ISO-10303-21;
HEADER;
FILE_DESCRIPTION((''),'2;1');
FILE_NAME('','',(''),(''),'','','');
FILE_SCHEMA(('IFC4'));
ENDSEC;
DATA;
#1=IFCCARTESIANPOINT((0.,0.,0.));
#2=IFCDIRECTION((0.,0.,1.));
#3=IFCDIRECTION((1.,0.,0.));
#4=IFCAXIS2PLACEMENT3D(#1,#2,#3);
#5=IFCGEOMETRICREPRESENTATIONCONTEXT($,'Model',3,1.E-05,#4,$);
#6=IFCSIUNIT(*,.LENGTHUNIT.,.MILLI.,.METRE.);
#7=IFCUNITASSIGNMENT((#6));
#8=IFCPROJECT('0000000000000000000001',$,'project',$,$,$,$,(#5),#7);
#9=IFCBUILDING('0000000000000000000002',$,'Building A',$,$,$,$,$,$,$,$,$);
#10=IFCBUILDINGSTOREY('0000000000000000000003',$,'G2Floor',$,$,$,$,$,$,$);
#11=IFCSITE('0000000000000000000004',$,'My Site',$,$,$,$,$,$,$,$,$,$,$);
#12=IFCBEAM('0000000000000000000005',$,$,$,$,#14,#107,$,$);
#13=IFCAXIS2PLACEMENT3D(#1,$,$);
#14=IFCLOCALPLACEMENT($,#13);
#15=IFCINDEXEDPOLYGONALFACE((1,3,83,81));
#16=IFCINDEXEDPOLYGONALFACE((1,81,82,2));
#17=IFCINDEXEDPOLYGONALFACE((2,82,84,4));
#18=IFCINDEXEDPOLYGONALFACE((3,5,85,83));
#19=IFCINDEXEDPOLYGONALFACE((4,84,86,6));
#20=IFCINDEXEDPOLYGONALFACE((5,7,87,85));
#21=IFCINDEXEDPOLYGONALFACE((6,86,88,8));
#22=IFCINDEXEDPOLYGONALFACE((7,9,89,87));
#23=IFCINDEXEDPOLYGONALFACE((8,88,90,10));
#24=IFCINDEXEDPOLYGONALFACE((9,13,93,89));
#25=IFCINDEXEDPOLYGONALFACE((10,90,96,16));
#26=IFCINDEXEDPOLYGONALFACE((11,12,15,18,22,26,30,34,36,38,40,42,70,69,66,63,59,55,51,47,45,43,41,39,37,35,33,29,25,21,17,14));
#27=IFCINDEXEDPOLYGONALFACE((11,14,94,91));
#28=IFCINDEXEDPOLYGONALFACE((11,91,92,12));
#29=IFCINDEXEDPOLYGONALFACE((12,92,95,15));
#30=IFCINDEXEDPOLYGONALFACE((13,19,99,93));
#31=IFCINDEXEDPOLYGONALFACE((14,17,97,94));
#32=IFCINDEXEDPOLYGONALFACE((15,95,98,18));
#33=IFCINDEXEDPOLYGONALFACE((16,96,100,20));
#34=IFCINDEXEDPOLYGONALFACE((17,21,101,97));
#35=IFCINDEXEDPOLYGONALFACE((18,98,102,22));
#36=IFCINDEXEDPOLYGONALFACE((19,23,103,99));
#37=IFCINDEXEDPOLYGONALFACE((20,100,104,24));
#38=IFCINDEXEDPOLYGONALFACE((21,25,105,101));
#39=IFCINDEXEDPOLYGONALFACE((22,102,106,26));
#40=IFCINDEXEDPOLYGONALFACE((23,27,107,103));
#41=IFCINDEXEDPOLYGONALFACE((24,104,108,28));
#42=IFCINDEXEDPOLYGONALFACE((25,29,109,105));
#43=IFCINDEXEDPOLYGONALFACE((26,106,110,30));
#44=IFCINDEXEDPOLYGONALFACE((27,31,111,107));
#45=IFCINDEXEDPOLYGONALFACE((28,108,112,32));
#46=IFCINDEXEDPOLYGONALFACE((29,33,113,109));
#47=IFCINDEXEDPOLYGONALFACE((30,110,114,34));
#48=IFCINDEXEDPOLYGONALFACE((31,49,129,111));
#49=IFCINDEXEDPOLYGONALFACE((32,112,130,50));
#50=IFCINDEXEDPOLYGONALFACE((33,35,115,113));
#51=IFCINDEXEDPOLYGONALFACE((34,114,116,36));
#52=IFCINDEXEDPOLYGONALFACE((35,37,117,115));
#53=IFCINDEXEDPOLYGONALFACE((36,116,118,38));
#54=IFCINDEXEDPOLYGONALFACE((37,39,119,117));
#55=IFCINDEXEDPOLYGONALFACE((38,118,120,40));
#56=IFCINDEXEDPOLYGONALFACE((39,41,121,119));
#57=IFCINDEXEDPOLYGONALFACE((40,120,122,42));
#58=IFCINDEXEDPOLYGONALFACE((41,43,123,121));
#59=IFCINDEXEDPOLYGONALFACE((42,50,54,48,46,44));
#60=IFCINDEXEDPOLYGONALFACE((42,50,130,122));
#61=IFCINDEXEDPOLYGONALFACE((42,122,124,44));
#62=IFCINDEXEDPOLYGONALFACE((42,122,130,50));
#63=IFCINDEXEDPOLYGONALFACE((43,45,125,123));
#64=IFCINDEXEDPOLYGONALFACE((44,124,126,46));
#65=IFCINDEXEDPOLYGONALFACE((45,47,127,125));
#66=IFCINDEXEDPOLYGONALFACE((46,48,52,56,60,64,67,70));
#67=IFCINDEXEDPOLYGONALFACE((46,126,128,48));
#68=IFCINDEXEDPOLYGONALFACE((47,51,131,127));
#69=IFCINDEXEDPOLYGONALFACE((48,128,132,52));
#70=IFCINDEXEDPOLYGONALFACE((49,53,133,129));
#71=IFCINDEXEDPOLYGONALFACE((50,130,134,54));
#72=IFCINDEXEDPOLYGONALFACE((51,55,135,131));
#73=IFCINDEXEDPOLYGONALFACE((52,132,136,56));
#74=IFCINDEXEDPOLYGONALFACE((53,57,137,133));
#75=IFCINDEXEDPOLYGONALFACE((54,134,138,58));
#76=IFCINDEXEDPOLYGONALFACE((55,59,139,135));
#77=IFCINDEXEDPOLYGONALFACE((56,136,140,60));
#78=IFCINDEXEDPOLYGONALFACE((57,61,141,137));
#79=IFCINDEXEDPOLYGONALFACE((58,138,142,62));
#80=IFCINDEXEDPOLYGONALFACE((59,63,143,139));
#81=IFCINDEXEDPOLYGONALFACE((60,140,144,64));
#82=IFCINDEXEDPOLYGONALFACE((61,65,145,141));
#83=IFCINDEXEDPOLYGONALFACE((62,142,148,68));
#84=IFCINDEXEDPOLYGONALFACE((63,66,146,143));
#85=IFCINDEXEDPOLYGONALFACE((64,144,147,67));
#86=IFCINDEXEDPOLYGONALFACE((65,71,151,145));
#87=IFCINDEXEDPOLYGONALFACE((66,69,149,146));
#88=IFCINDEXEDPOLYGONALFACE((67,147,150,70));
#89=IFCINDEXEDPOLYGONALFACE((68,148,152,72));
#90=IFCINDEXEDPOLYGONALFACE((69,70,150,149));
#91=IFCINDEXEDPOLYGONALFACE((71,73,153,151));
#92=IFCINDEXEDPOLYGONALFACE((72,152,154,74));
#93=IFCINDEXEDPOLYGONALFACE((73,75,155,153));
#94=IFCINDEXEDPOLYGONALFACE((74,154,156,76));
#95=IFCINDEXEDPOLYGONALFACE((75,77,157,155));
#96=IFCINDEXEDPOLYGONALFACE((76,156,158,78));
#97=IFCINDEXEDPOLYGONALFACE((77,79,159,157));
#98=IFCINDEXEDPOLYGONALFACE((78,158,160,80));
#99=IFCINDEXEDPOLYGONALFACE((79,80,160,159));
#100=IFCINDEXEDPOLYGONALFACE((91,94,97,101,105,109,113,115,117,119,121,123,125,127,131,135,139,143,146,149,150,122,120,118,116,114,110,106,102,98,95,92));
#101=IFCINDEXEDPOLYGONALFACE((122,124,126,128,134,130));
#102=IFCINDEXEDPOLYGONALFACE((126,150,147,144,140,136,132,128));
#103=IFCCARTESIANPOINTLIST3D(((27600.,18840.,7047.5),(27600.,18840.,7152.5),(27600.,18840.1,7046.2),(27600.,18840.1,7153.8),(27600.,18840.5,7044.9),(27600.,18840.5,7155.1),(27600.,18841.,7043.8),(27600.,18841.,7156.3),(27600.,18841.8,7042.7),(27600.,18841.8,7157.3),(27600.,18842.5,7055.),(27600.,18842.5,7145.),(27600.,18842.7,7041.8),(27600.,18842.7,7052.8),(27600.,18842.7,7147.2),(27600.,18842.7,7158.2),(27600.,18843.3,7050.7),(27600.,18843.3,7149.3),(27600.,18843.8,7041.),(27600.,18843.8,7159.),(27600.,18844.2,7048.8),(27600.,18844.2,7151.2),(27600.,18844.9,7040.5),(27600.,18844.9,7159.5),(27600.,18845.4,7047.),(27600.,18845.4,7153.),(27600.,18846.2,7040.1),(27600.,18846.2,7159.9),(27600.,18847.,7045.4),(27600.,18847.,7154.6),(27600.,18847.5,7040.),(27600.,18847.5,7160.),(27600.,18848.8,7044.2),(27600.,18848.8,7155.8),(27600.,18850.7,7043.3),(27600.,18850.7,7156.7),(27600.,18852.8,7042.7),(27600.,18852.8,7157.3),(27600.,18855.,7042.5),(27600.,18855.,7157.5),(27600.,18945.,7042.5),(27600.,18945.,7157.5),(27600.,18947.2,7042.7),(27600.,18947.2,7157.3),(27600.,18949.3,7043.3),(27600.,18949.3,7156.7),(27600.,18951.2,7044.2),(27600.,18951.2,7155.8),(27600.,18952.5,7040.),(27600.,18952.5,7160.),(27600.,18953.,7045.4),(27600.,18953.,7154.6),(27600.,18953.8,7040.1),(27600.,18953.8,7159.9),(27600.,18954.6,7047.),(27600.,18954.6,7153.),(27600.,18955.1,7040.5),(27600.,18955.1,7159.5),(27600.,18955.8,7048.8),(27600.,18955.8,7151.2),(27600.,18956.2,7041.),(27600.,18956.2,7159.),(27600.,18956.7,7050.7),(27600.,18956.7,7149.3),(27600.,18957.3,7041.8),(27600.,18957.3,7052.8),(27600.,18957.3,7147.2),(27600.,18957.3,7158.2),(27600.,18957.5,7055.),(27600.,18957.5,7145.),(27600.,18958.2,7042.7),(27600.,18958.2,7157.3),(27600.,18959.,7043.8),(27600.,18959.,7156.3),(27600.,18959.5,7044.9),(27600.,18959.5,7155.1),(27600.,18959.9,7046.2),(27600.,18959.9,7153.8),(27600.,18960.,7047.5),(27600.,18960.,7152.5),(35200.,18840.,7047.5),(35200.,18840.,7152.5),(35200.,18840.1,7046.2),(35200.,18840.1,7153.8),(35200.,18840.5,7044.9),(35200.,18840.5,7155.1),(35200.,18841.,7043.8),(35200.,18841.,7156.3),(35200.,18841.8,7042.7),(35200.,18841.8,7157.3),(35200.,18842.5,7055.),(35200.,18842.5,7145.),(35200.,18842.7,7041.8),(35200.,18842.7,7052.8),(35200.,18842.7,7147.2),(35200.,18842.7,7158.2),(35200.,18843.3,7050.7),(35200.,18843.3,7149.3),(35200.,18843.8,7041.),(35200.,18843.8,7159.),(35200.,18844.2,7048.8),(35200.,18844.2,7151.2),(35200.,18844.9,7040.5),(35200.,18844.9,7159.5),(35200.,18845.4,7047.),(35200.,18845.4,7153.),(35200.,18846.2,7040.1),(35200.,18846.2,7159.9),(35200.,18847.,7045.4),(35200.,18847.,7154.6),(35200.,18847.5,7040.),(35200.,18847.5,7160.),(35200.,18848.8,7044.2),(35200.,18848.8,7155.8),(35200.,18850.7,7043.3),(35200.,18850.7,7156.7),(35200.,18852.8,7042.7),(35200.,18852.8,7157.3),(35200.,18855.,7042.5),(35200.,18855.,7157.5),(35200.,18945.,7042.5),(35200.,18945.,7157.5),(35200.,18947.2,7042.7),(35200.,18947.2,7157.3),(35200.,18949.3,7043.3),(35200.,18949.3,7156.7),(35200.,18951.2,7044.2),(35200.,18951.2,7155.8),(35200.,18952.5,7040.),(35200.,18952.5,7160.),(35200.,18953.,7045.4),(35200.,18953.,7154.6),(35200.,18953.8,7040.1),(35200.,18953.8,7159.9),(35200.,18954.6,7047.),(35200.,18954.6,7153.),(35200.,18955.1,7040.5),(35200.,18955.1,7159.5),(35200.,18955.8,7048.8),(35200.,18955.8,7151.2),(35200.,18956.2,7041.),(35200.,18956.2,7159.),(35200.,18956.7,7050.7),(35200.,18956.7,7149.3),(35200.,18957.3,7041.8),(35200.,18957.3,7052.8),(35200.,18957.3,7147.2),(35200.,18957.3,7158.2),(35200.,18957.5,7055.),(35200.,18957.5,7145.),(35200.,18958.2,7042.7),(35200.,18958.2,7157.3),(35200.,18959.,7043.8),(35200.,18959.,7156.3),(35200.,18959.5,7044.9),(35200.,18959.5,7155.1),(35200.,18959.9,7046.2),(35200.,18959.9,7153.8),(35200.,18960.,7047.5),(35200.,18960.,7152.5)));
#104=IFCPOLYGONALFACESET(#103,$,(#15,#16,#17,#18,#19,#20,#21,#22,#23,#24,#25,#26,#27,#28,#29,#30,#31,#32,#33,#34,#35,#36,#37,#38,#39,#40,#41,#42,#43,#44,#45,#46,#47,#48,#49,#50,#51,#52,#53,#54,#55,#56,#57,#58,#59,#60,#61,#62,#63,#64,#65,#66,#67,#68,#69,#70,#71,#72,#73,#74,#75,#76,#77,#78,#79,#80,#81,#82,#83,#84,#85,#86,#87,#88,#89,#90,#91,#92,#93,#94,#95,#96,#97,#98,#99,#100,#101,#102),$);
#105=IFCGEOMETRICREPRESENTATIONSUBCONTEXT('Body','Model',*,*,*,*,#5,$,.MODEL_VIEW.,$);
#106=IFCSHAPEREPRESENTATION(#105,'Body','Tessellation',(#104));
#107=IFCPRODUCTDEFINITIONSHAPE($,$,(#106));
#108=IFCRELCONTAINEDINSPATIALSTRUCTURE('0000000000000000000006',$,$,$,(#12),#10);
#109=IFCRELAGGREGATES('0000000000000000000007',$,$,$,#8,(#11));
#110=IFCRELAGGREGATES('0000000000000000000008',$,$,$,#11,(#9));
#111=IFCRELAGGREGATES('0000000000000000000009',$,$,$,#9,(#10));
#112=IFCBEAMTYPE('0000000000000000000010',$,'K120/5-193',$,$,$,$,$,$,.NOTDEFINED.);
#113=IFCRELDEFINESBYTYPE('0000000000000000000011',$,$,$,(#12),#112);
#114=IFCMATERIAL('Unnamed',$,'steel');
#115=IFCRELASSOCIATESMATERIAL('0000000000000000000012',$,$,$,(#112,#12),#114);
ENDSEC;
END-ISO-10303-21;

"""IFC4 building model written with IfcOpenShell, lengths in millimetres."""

from ifc_helpers import new_model, si_unit, frame, origin_with_axes, place, context, subcontext, project, spatial, polyline, outline, extrude, material, material_profile, profile_set, profile_usage, type_object, element, save


model = new_model("IFC4")

# Units and contexts
model_context = context("Model", 3, precision=1e-05, world=origin_with_axes())
body_context = subcontext(model_context, "Body", "Model", "MODEL_VIEW")
ifc_project = project(units=[si_unit("LENGTHUNIT", "METRE", prefix="MILLI")], contexts=[model_context])

# Site, building, storey
site = spatial("IfcSite", under=ifc_project, Name="My Site")
building = spatial("IfcBuilding", under=site, Name="Building A")
storey = spatial("IfcBuildingStorey", under=building, Name="G2Floor")

# Beam
ifc_material_1 = material(Name="Unnamed", Category="steel")
ifc_material_profile_1 = material_profile(ifc_material_1, outline(polyline([(-52.5, -60.0), (52.5, -60.0), (52.5, -60.0), (53.8, -59.9), (53.8, -59.9), (55.1, -59.5), (55.1, -59.5), (56.2, -59.0), (56.2, -59.0), (57.3, -58.2), (57.3, -58.2), (58.2, -57.3), (58.2, -57.3), (59.0, -56.2), (59.0, -56.2), (59.5, -55.1), (59.5, -55.1), (59.9, -53.8), (59.9, -53.8), (60.0, -52.5), (60.0, -52.5), (60.0, 52.5), (60.0, 52.5), (59.9, 53.8), (59.9, 53.8), (59.5, 55.1), (59.5, 55.1), (59.0, 56.2), (59.0, 56.2), (58.2, 57.3), (58.2, 57.3), (57.3, 58.2), (57.3, 58.2), (56.2, 59.0), (56.2, 59.0), (55.1, 59.5), (55.1, 59.5), (53.8, 59.9), (53.8, 59.9), (52.5, 60.0), (52.5, 60.0), (-52.5, 60.0), (-52.5, 60.0), (-53.8, 59.9), (-53.8, 59.9), (-55.1, 59.5), (-55.1, 59.5), (-56.2, 59.0), (-56.2, 59.0), (-57.3, 58.2), (-57.3, 58.2), (-58.2, 57.3), (-58.2, 57.3), (-59.0, 56.2), (-59.0, 56.2), (-59.5, 55.1), (-59.5, 55.1), (-59.9, 53.8), (-59.9, 53.8), (-60.0, 52.5), (-60.0, 52.5), (-60.0, -52.5), (-60.0, -52.5), (-59.9, -53.8), (-59.9, -53.8), (-59.5, -55.1), (-59.5, -55.1), (-59.0, -56.2), (-59.0, -56.2), (-58.2, -57.3), (-58.2, -57.3), (-57.3, -58.2), (-57.3, -58.2), (-56.2, -59.0), (-56.2, -59.0), (-55.1, -59.5), (-55.1, -59.5), (-53.8, -59.9), (-53.8, -59.9), (-52.5, -60.0), (-52.5, -60.0), (-45.0, -57.5), (-45.0, -57.5), (45.0, -57.5), (45.0, -57.5), (47.2, -57.3), (47.2, -57.3), (49.3, -56.7), (49.3, -56.7), (51.2, -55.8), (51.2, -55.8), (53.0, -54.6), (53.0, -54.6), (54.6, -53.0), (54.6, -53.0), (55.8, -51.2), (55.8, -51.2), (56.7, -49.3), (56.7, -49.3), (57.3, -47.2), (57.3, -47.2), (57.5, -45.0), (57.5, -45.0), (57.5, 45.0), (57.5, 45.0), (57.3, 47.2), (57.3, 47.2), (56.7, 49.3), (56.7, 49.3), (55.8, 51.2), (55.8, 51.2), (54.6, 53.0), (54.6, 53.0), (53.0, 54.6), (53.0, 54.6), (51.2, 55.8), (51.2, 55.8), (49.3, 56.7), (49.3, 56.7), (47.2, 57.3), (47.2, 57.3), (45.0, 57.5), (45.0, 57.5), (-45.0, 57.5), (-45.0, 57.5), (-47.2, 57.3), (-47.2, 57.3), (-49.3, 56.7), (-49.3, 56.7), (-51.2, 55.8), (-51.2, 55.8), (-53.0, 54.6), (-53.0, 54.6), (-54.6, 53.0), (-54.6, 53.0), (-55.8, 51.2), (-55.8, 51.2), (-56.7, 49.3), (-56.7, 49.3), (-57.3, 47.2), (-57.3, 47.2), (-57.5, 45.0), (-57.5, 45.0), (-57.5, -45.0), (-57.5, -45.0), (-57.3, -47.2), (-57.3, -47.2), (-56.7, -49.3), (-56.7, -49.3), (-55.8, -51.2), (-55.8, -51.2), (-54.6, -53.0), (-54.6, -53.0), (-53.0, -54.6), (-53.0, -54.6), (-51.2, -55.8), (-51.2, -55.8), (-49.3, -56.7), (-49.3, -56.7), (-47.2, -57.3), (-47.2, -57.3), (-45.0, -57.5), (-45.0, -57.5), (-52.5, -60.0)])))
ifc_profile_set_1 = profile_set([ifc_material_profile_1], Name="K120/5-193")
ifc_profile_usage_1 = profile_usage(ifc_profile_set_1)
beam_type_1 = type_object("IfcBeamType", Name="K120/5-193", PredefinedType="NOTDEFINED", material=ifc_profile_set_1)
beam_1_placement = place(None, frame((27600.0, 18900.0, 7100.0), z_axis=(1.0, 0.0, 0.0), x_axis=(0.0, -1.0, 0.0)))
element("IfcBeam", 1, at=beam_1_placement, inside=storey, type_object=beam_type_1, material=ifc_profile_usage_1, context=body_context, shape_type="SweptSolid", body=[
    extrude(outline(polyline([(-52.5, -60.0), (52.5, -60.0), (52.5, -60.0), (53.8, -59.9), (53.8, -59.9), (55.1, -59.5), (55.1, -59.5), (56.2, -59.0), (56.2, -59.0), (57.3, -58.2), (57.3, -58.2), (58.2, -57.3), (58.2, -57.3), (59.0, -56.2), (59.0, -56.2), (59.5, -55.1), (59.5, -55.1), (59.9, -53.8), (59.9, -53.8), (60.0, -52.5), (60.0, -52.5), (60.0, 52.5), (60.0, 52.5), (59.9, 53.8), (59.9, 53.8), (59.5, 55.1), (59.5, 55.1), (59.0, 56.2), (59.0, 56.2), (58.2, 57.3), (58.2, 57.3), (57.3, 58.2), (57.3, 58.2), (56.2, 59.0), (56.2, 59.0), (55.1, 59.5), (55.1, 59.5), (53.8, 59.9), (53.8, 59.9), (52.5, 60.0), (52.5, 60.0), (-52.5, 60.0), (-52.5, 60.0), (-53.8, 59.9), (-53.8, 59.9), (-55.1, 59.5), (-55.1, 59.5), (-56.2, 59.0), (-56.2, 59.0), (-57.3, 58.2), (-57.3, 58.2), (-58.2, 57.3), (-58.2, 57.3), (-59.0, 56.2), (-59.0, 56.2), (-59.5, 55.1), (-59.5, 55.1), (-59.9, 53.8), (-59.9, 53.8), (-60.0, 52.5), (-60.0, 52.5), (-60.0, -52.5), (-60.0, -52.5), (-59.9, -53.8), (-59.9, -53.8), (-59.5, -55.1), (-59.5, -55.1), (-59.0, -56.2), (-59.0, -56.2), (-58.2, -57.3), (-58.2, -57.3), (-57.3, -58.2), (-57.3, -58.2), (-56.2, -59.0), (-56.2, -59.0), (-55.1, -59.5), (-55.1, -59.5), (-53.8, -59.9), (-53.8, -59.9), (-52.5, -60.0), (-52.5, -60.0), (-45.0, -57.5), (-45.0, -57.5), (45.0, -57.5), (45.0, -57.5), (47.2, -57.3), (47.2, -57.3), (49.3, -56.7), (49.3, -56.7), (51.2, -55.8), (51.2, -55.8), (53.0, -54.6), (53.0, -54.6), (54.6, -53.0), (54.6, -53.0), (55.8, -51.2), (55.8, -51.2), (56.7, -49.3), (56.7, -49.3), (57.3, -47.2), (57.3, -47.2), (57.5, -45.0), (57.5, -45.0), (57.5, 45.0), (57.5, 45.0), (57.3, 47.2), (57.3, 47.2), (56.7, 49.3), (56.7, 49.3), (55.8, 51.2), (55.8, 51.2), (54.6, 53.0), (54.6, 53.0), (53.0, 54.6), (53.0, 54.6), (51.2, 55.8), (51.2, 55.8), (49.3, 56.7), (49.3, 56.7), (47.2, 57.3), (47.2, 57.3), (45.0, 57.5), (45.0, 57.5), (-45.0, 57.5), (-45.0, 57.5), (-47.2, 57.3), (-47.2, 57.3), (-49.3, 56.7), (-49.3, 56.7), (-51.2, 55.8), (-51.2, 55.8), (-53.0, 54.6), (-53.0, 54.6), (-54.6, 53.0), (-54.6, 53.0), (-55.8, 51.2), (-55.8, 51.2), (-56.7, 49.3), (-56.7, 49.3), (-57.3, 47.2), (-57.3, 47.2), (-57.5, 45.0), (-57.5, 45.0), (-57.5, -45.0), (-57.5, -45.0), (-57.3, -47.2), (-57.3, -47.2), (-56.7, -49.3), (-56.7, -49.3), (-55.8, -51.2), (-55.8, -51.2), (-54.6, -53.0), (-54.6, -53.0), (-53.0, -54.6), (-53.0, -54.6), (-51.2, -55.8), (-51.2, -55.8), (-49.3, -56.7), (-49.3, -56.7), (-47.2, -57.3), (-47.2, -57.3), (-45.0, -57.5), (-45.0, -57.5), (-52.5, -60.0)])), origin_with_axes(), (0.0, 0.0, 1.0), 7600.0),
])

save(model, "model.ifc")
